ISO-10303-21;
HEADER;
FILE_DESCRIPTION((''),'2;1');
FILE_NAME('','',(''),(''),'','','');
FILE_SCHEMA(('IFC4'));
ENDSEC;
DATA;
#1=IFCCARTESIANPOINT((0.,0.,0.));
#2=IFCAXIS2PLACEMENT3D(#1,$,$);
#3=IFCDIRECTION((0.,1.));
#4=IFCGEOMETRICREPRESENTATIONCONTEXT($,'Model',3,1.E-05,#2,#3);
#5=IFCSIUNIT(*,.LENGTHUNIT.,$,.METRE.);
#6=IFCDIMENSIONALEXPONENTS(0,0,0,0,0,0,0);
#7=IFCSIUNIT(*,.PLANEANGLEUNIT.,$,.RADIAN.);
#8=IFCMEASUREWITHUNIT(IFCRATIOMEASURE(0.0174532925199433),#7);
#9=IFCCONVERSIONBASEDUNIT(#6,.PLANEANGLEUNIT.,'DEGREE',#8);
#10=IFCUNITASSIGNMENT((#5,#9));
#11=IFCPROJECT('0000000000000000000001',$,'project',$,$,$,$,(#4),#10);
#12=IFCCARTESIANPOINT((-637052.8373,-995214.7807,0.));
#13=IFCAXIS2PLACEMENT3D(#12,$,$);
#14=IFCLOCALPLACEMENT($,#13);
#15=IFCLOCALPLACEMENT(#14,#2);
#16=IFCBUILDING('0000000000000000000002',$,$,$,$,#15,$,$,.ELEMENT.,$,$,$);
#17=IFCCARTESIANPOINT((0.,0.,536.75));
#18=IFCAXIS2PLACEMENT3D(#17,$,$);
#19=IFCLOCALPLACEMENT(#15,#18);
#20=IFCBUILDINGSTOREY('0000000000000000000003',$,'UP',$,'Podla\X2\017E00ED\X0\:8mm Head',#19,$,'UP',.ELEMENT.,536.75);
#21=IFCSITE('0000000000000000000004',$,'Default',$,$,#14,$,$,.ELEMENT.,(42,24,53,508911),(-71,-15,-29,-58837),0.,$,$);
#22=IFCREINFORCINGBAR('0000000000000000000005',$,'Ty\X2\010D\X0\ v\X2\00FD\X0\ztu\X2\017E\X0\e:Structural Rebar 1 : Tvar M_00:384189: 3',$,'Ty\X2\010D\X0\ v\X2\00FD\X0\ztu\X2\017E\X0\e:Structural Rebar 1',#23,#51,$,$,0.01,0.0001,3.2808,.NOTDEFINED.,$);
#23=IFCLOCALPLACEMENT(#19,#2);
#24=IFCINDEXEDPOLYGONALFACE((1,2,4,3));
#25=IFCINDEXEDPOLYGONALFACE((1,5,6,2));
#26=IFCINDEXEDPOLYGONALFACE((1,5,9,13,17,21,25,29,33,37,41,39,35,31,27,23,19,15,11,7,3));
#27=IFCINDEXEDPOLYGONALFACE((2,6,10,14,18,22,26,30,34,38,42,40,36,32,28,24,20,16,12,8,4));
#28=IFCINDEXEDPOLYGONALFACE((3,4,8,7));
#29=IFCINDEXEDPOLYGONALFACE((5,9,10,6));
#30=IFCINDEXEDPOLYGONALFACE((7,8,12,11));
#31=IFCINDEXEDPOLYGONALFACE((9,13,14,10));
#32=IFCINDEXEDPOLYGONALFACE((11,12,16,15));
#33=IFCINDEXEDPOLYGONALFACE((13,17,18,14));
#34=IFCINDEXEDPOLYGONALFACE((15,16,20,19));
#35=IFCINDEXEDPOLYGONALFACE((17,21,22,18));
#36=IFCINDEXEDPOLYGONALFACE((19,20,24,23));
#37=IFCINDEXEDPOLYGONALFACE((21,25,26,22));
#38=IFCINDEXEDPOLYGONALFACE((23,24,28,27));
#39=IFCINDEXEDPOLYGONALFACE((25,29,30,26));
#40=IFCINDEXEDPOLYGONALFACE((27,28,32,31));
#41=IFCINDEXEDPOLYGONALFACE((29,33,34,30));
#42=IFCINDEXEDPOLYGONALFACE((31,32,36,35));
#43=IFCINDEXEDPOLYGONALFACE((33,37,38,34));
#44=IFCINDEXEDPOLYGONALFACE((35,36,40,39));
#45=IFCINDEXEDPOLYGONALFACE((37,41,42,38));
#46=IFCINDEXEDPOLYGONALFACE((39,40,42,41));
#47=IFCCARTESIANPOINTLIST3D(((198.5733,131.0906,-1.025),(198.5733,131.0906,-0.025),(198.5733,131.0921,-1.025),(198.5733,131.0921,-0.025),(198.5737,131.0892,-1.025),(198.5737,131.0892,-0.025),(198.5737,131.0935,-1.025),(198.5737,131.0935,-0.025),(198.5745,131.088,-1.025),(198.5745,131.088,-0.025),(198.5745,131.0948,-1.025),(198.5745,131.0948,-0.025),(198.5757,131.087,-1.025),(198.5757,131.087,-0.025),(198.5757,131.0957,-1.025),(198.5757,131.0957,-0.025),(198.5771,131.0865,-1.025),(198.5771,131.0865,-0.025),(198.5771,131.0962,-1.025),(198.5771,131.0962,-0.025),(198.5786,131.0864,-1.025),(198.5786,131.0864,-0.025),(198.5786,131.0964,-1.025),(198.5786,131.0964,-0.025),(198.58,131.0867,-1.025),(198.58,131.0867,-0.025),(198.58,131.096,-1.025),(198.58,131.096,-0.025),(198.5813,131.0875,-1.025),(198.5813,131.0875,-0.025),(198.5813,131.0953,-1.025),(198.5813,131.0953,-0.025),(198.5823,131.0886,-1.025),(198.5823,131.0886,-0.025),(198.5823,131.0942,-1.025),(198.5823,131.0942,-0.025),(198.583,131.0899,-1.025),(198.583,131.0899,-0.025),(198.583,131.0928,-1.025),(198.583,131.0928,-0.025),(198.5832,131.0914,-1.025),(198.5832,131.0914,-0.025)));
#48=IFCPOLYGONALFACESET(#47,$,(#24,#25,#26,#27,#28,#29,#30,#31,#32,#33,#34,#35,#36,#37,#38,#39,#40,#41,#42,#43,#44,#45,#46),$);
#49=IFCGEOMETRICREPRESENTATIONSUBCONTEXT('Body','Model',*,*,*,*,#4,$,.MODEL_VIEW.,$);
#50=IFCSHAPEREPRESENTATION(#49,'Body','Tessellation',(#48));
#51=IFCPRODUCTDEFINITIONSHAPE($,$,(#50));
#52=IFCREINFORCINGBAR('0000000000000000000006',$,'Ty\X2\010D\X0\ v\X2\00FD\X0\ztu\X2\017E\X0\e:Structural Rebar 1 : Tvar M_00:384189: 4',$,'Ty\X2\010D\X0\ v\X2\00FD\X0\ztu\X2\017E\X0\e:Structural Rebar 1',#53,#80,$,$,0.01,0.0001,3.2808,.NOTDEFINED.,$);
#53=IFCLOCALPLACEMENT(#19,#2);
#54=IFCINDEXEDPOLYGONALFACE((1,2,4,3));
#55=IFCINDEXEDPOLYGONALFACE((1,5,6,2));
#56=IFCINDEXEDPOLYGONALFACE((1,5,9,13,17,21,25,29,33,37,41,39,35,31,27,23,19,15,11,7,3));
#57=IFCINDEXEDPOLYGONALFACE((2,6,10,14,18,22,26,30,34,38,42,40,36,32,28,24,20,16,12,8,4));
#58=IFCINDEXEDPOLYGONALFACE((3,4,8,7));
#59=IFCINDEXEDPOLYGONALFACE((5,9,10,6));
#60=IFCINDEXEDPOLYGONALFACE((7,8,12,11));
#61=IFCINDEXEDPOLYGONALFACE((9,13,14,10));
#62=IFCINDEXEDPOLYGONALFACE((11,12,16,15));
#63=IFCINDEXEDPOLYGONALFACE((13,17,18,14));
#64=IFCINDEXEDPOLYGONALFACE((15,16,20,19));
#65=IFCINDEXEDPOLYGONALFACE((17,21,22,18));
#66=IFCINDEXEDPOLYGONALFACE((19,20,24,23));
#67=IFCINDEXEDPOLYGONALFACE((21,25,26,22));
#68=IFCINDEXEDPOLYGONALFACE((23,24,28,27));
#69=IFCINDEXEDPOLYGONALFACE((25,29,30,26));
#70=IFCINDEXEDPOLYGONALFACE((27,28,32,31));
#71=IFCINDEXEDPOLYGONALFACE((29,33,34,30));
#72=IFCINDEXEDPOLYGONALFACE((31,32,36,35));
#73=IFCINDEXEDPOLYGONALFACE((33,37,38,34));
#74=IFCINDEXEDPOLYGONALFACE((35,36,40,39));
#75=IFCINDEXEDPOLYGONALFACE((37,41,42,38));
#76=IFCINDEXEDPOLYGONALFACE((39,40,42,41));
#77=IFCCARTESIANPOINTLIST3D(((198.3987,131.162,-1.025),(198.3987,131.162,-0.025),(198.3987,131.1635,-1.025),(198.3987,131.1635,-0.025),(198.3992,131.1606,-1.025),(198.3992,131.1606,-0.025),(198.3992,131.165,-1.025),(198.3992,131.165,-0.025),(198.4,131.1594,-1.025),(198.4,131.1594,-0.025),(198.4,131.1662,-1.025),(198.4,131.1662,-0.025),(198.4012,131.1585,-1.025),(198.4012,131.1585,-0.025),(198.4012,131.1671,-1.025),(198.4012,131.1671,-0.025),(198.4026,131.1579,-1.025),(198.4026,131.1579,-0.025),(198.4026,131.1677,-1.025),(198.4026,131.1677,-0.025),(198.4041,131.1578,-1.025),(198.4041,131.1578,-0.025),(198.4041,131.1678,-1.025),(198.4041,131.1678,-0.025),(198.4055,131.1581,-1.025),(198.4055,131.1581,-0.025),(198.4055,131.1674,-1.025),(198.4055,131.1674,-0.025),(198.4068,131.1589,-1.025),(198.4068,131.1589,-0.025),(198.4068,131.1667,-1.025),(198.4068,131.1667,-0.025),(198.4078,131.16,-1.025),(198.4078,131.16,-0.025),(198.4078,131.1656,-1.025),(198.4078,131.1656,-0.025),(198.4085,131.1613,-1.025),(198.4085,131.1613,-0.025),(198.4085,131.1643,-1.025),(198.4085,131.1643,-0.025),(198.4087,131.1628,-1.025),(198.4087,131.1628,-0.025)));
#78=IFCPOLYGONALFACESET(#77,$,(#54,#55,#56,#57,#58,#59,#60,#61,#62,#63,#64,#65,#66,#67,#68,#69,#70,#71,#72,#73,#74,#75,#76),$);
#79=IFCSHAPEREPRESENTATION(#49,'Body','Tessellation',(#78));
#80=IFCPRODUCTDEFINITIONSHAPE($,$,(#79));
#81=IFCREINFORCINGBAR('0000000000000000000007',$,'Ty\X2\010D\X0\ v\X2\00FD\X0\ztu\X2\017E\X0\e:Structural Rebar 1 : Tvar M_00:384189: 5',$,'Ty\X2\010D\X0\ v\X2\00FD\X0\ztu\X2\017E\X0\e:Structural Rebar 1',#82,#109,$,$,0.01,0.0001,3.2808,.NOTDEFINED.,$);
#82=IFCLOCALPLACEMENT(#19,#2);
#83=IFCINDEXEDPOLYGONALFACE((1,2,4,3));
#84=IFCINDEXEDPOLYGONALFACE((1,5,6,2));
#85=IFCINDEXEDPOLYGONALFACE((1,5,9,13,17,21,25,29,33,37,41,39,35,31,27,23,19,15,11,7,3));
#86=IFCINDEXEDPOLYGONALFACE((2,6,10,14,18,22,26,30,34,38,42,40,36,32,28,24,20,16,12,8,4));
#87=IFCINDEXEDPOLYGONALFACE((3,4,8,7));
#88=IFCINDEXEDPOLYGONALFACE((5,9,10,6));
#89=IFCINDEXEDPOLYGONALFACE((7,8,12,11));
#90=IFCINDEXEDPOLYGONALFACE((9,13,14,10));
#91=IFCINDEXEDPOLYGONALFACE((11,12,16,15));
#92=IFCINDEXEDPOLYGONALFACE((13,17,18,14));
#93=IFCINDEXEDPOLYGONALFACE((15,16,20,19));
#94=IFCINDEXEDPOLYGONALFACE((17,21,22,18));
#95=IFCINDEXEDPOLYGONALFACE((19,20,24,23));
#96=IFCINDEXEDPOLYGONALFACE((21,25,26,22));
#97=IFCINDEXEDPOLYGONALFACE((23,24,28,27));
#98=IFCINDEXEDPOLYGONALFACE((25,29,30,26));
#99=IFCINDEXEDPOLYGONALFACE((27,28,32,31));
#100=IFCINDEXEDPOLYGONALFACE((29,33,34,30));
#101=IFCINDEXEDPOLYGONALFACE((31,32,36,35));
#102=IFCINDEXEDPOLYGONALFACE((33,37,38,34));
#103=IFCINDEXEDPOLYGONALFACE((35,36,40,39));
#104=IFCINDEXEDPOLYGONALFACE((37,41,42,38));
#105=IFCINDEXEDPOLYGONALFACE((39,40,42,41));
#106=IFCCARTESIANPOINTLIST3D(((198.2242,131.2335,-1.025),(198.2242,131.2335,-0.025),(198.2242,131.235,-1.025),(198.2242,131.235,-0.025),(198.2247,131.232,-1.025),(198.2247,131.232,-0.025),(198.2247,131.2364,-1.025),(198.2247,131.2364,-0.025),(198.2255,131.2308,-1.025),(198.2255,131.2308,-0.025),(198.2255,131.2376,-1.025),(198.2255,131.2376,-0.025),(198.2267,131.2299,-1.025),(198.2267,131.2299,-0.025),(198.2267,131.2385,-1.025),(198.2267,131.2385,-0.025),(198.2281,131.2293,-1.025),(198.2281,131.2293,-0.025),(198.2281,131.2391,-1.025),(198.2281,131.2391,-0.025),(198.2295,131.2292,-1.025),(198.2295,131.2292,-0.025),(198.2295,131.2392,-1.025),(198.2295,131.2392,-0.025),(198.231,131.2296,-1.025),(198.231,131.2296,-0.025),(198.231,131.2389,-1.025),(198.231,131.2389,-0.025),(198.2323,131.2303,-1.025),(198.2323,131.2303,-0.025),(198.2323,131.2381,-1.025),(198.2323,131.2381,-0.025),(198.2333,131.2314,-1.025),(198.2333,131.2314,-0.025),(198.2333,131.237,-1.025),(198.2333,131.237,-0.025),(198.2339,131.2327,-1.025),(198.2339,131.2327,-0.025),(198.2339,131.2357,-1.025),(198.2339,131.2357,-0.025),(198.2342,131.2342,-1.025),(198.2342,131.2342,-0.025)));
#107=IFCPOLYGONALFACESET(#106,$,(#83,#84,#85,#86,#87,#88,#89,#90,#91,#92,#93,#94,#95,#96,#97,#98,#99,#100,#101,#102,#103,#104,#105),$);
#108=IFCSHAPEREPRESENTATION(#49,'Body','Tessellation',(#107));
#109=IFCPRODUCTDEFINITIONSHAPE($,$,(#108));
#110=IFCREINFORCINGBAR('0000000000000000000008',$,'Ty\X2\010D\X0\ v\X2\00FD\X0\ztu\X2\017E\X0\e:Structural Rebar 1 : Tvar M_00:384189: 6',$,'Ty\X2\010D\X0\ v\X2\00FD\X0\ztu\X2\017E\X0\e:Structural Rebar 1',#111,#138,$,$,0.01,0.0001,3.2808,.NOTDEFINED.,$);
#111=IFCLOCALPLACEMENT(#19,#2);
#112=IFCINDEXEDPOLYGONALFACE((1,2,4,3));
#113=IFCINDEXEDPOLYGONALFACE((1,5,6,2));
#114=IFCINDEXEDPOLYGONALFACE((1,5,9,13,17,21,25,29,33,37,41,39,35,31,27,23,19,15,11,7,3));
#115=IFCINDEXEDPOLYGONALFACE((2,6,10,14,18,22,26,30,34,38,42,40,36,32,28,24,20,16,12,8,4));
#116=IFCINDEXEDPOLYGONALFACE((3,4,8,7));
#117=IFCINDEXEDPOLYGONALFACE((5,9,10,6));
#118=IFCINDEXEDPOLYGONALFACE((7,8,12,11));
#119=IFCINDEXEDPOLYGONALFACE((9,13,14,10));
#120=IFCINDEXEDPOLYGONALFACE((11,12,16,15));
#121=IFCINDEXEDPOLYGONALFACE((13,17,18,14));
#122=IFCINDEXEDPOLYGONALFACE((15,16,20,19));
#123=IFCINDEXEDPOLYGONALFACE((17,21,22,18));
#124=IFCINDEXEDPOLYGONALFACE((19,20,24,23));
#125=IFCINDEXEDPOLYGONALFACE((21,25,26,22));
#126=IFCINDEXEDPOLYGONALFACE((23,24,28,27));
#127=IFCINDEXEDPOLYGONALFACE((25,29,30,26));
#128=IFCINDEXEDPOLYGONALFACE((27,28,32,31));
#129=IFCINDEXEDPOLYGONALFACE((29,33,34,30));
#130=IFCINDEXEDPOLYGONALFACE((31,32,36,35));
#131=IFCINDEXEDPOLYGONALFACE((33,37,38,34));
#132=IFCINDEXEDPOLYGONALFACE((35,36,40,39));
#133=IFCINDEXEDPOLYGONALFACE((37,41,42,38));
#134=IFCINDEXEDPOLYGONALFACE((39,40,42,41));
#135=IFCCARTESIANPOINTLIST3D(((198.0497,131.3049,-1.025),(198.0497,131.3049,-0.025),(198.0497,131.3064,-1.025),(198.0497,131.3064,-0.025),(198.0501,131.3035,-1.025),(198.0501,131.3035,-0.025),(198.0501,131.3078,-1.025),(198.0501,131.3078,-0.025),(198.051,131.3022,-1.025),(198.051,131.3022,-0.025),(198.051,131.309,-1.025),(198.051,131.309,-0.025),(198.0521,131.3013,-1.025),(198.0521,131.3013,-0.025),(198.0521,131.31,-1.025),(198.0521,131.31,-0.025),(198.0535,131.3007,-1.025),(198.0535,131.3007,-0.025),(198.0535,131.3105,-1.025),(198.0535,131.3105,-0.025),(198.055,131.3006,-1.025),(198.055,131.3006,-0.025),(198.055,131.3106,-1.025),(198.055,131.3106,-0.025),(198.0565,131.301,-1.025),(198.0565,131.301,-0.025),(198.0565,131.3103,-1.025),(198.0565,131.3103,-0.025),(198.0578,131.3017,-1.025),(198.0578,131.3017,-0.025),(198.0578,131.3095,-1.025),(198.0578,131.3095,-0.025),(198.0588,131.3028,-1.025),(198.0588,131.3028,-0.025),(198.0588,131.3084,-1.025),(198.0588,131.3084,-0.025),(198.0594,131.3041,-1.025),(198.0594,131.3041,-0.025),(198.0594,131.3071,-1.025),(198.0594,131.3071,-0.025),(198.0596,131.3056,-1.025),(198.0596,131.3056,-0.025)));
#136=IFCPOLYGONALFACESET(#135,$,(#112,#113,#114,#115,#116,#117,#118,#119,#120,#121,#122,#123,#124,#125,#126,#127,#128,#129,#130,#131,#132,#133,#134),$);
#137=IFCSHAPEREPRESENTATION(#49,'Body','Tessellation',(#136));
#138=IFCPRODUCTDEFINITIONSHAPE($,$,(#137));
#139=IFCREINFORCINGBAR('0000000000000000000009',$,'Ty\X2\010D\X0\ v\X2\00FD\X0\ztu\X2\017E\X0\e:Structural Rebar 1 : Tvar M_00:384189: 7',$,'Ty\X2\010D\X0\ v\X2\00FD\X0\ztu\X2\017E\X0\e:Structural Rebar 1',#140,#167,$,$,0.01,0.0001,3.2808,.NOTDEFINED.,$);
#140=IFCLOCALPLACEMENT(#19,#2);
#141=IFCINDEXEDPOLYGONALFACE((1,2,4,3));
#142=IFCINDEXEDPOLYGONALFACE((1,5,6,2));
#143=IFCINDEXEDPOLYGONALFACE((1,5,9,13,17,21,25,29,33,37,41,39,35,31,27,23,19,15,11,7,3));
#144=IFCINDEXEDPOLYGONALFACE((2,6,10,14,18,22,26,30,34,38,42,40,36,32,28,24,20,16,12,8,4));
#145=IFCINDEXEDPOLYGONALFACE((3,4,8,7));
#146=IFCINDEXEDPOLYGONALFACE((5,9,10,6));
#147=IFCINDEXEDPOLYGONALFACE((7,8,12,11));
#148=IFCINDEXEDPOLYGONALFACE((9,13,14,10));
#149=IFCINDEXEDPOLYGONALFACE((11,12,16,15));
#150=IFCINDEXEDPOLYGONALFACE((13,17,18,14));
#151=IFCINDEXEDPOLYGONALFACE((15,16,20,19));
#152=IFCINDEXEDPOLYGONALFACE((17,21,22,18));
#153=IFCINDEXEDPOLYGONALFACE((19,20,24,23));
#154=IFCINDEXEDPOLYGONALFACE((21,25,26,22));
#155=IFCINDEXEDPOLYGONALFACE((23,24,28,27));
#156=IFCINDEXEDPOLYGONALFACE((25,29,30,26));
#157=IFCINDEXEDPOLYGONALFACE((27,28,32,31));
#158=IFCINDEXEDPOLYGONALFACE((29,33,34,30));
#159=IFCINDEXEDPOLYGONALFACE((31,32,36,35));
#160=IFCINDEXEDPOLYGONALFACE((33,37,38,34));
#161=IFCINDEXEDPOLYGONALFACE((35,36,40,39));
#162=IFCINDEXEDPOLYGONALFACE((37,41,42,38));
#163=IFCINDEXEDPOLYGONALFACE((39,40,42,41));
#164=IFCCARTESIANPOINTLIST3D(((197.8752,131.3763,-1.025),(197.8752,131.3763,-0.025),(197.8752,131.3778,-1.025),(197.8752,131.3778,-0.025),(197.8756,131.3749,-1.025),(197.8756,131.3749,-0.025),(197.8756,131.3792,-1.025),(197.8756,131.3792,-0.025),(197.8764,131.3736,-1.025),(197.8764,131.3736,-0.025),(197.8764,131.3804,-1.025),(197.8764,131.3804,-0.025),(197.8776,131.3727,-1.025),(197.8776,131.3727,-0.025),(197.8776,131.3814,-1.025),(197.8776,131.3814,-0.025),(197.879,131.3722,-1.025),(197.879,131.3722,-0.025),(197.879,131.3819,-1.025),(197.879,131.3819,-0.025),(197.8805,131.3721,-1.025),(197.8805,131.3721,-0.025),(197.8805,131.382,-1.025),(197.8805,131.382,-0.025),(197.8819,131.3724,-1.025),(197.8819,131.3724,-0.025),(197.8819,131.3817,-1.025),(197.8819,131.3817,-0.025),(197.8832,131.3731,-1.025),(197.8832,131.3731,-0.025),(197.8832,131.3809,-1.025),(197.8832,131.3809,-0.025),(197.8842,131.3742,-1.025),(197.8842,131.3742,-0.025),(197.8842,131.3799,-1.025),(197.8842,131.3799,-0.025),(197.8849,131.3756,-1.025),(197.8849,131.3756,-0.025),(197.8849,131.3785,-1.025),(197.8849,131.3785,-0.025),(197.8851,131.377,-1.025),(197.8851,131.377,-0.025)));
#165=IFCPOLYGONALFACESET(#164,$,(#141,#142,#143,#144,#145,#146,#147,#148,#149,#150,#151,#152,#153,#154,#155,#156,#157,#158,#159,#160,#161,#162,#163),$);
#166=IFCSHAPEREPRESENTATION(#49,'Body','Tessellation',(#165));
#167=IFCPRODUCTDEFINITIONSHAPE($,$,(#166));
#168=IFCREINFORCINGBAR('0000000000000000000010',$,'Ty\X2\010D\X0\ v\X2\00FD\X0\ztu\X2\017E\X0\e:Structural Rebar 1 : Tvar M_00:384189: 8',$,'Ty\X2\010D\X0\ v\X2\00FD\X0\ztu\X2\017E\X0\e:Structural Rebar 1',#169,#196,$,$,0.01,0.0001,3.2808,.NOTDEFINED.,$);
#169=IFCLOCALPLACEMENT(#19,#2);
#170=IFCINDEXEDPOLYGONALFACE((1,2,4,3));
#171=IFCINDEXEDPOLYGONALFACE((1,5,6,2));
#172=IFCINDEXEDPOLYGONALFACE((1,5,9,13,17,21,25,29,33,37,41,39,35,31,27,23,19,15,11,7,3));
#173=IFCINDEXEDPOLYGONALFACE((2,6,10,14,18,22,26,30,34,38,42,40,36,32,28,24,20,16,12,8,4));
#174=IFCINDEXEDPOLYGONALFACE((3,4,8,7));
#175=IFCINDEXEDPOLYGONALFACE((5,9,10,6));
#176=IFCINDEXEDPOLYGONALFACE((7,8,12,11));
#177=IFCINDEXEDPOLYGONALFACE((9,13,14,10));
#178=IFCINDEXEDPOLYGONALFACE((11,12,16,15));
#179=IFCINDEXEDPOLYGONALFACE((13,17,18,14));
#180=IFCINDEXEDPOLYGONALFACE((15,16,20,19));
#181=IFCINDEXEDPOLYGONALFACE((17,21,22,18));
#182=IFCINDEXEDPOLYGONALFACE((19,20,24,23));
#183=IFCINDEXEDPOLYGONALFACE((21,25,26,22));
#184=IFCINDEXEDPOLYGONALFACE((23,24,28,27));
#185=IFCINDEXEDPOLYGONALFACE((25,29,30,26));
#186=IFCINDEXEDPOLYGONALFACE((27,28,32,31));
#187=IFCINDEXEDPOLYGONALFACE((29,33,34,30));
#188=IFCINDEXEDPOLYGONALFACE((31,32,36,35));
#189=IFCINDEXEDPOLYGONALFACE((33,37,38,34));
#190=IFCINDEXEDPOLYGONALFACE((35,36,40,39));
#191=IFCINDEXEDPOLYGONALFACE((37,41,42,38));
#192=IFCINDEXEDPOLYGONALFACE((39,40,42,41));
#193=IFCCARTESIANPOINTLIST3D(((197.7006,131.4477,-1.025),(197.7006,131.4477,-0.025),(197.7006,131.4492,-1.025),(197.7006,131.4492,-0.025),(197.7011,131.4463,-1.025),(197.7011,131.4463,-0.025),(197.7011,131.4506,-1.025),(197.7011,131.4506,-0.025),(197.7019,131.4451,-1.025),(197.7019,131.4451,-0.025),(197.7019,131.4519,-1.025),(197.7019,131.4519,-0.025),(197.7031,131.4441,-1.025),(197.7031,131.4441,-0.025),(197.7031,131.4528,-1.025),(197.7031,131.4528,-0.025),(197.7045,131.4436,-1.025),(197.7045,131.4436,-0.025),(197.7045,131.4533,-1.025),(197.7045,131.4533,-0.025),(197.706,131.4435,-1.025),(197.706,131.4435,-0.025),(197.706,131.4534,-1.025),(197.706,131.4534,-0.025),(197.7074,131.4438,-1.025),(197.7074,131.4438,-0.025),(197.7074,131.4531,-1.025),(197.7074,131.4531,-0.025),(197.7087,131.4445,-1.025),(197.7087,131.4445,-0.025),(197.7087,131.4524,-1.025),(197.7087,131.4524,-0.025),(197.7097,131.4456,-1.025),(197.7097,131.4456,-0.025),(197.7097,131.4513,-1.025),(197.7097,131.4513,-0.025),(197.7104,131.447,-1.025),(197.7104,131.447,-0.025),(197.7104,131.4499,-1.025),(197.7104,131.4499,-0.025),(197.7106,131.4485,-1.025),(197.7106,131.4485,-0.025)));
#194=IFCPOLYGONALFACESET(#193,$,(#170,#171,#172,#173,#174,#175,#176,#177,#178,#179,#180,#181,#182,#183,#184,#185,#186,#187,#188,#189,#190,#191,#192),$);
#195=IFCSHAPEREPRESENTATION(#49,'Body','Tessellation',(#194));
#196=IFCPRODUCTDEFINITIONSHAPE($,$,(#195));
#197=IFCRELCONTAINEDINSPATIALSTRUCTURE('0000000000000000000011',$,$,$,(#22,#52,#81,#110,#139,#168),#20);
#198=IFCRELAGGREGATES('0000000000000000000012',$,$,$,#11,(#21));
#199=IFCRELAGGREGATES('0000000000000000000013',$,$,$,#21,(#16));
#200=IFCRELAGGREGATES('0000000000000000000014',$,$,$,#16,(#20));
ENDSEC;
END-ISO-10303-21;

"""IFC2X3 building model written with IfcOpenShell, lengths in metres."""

from ifc_helpers import new_model, entity, si_unit, converted_unit, direction, frame, origin, place, context, subcontext, project, spatial, element, save


model = new_model("IFC2X3")

# Units and contexts
model_context = context("Model", 3, precision=1e-05, world=origin(), true_north=direction((0.0, 1.0)))
body_context = subcontext(model_context, "Body", "Model", "MODEL_VIEW")
ifc_project = project(units=[si_unit("LENGTHUNIT", "METRE"), converted_unit("PLANEANGLEUNIT", "DEGREE", entity("IfcRatioMeasure", 0.0174532925199433), si_unit("PLANEANGLEUNIT", "RADIAN"), dimensions=[0, 0, 0, 0, 0, 0, 0])], contexts=[model_context])

# Site, building, storey
site_placement = place(None, frame((-637052.8373, -995214.7807, 0.0)))
site = spatial("IfcSite", under=ifc_project, at=site_placement, Name="Default", CompositionType="ELEMENT", RefLatitude=(42, 24, 53, 508911), RefLongitude=(-71, -15, -29, -58837), RefElevation=0.0)
building_placement = place(site_placement, origin())
building = spatial("IfcBuilding", under=site, at=building_placement, CompositionType="ELEMENT")
storey_placement = place(building_placement, frame((0.0, 0.0, 536.75)))
storey = spatial("IfcBuildingStorey", under=building, at=storey_placement, Name="UP", ObjectType="Podlaží:8mm Head", LongName="UP", CompositionType="ELEMENT", Elevation=536.75)

# Reinforcing bars
reinforcing_bar_1_placement = place(storey_placement, origin())
element("IfcReinforcingBar", 1, at=reinforcing_bar_1_placement, inside=storey, Name="Tyč výztuže:Structural Rebar 1 : Tvar M_00:384189: 3", ObjectType="Tyč výztuže:Structural Rebar 1", BarLength=3.2808, BarRole="NOTDEFINED", CrossSectionArea=0.0001, NominalDiameter=0.01, context=body_context, shape_type="AdvancedSweptSolid", body=[
    entity("IfcSweptDiskSolid", entity("IfcCompositeCurve", [entity("IfcCompositeCurveSegment", "CONTINUOUS", True, entity("IfcPolyline", [entity("IfcCartesianPoint", [-198.5782, -131.0914, 0.025]), entity("IfcCartesianPoint", [-198.5782, -131.0914, 1.025])]))], False), 0.005, None, 0.0, 1.0),
])
reinforcing_bar_2_placement = place(storey_placement, origin())
element("IfcReinforcingBar", 2, at=reinforcing_bar_2_placement, inside=storey, Name="Tyč výztuže:Structural Rebar 1 : Tvar M_00:384189: 4", ObjectType="Tyč výztuže:Structural Rebar 1", BarLength=3.2808, BarRole="NOTDEFINED", CrossSectionArea=0.0001, NominalDiameter=0.01, context=body_context, shape_type="AdvancedSweptSolid", body=[
    entity("IfcSweptDiskSolid", entity("IfcCompositeCurve", [entity("IfcCompositeCurveSegment", "CONTINUOUS", True, entity("IfcPolyline", [entity("IfcCartesianPoint", [-198.4037, -131.1628, 0.025]), entity("IfcCartesianPoint", [-198.4037, -131.1628, 1.025])]))], False), 0.005, None, 0.0, 1.0),
])
reinforcing_bar_3_placement = place(storey_placement, origin())
element("IfcReinforcingBar", 3, at=reinforcing_bar_3_placement, inside=storey, Name="Tyč výztuže:Structural Rebar 1 : Tvar M_00:384189: 5", ObjectType="Tyč výztuže:Structural Rebar 1", BarLength=3.2808, BarRole="NOTDEFINED", CrossSectionArea=0.0001, NominalDiameter=0.01, context=body_context, shape_type="AdvancedSweptSolid", body=[
    entity("IfcSweptDiskSolid", entity("IfcCompositeCurve", [entity("IfcCompositeCurveSegment", "CONTINUOUS", True, entity("IfcPolyline", [entity("IfcCartesianPoint", [-198.2292, -131.2342, 0.025]), entity("IfcCartesianPoint", [-198.2292, -131.2342, 1.025])]))], False), 0.005, None, 0.0, 1.0),
])
reinforcing_bar_4_placement = place(storey_placement, origin())
element("IfcReinforcingBar", 4, at=reinforcing_bar_4_placement, inside=storey, Name="Tyč výztuže:Structural Rebar 1 : Tvar M_00:384189: 6", ObjectType="Tyč výztuže:Structural Rebar 1", BarLength=3.2808, BarRole="NOTDEFINED", CrossSectionArea=0.0001, NominalDiameter=0.01, context=body_context, shape_type="AdvancedSweptSolid", body=[
    entity("IfcSweptDiskSolid", entity("IfcCompositeCurve", [entity("IfcCompositeCurveSegment", "CONTINUOUS", True, entity("IfcPolyline", [entity("IfcCartesianPoint", [-198.0546, -131.3056, 0.025]), entity("IfcCartesianPoint", [-198.0546, -131.3056, 1.025])]))], False), 0.005, None, 0.0, 1.0),
])
reinforcing_bar_5_placement = place(storey_placement, origin())
element("IfcReinforcingBar", 5, at=reinforcing_bar_5_placement, inside=storey, Name="Tyč výztuže:Structural Rebar 1 : Tvar M_00:384189: 7", ObjectType="Tyč výztuže:Structural Rebar 1", BarLength=3.2808, BarRole="NOTDEFINED", CrossSectionArea=0.0001, NominalDiameter=0.01, context=body_context, shape_type="AdvancedSweptSolid", body=[
    entity("IfcSweptDiskSolid", entity("IfcCompositeCurve", [entity("IfcCompositeCurveSegment", "CONTINUOUS", True, entity("IfcPolyline", [entity("IfcCartesianPoint", [-197.8801, -131.377, 0.025]), entity("IfcCartesianPoint", [-197.8801, -131.377, 1.025])]))], False), 0.005, None, 0.0, 1.0),
])
reinforcing_bar_6_placement = place(storey_placement, origin())
element("IfcReinforcingBar", 6, at=reinforcing_bar_6_placement, inside=storey, Name="Tyč výztuže:Structural Rebar 1 : Tvar M_00:384189: 8", ObjectType="Tyč výztuže:Structural Rebar 1", BarLength=3.2808, BarRole="NOTDEFINED", CrossSectionArea=0.0001, NominalDiameter=0.01, context=body_context, shape_type="AdvancedSweptSolid", body=[
    entity("IfcSweptDiskSolid", entity("IfcCompositeCurve", [entity("IfcCompositeCurveSegment", "CONTINUOUS", True, entity("IfcPolyline", [entity("IfcCartesianPoint", [-197.7056, -131.4485, 0.025]), entity("IfcCartesianPoint", [-197.7056, -131.4485, 1.025])]))], False), 0.005, None, 0.0, 1.0),
])

save(model, "model.ifc")
